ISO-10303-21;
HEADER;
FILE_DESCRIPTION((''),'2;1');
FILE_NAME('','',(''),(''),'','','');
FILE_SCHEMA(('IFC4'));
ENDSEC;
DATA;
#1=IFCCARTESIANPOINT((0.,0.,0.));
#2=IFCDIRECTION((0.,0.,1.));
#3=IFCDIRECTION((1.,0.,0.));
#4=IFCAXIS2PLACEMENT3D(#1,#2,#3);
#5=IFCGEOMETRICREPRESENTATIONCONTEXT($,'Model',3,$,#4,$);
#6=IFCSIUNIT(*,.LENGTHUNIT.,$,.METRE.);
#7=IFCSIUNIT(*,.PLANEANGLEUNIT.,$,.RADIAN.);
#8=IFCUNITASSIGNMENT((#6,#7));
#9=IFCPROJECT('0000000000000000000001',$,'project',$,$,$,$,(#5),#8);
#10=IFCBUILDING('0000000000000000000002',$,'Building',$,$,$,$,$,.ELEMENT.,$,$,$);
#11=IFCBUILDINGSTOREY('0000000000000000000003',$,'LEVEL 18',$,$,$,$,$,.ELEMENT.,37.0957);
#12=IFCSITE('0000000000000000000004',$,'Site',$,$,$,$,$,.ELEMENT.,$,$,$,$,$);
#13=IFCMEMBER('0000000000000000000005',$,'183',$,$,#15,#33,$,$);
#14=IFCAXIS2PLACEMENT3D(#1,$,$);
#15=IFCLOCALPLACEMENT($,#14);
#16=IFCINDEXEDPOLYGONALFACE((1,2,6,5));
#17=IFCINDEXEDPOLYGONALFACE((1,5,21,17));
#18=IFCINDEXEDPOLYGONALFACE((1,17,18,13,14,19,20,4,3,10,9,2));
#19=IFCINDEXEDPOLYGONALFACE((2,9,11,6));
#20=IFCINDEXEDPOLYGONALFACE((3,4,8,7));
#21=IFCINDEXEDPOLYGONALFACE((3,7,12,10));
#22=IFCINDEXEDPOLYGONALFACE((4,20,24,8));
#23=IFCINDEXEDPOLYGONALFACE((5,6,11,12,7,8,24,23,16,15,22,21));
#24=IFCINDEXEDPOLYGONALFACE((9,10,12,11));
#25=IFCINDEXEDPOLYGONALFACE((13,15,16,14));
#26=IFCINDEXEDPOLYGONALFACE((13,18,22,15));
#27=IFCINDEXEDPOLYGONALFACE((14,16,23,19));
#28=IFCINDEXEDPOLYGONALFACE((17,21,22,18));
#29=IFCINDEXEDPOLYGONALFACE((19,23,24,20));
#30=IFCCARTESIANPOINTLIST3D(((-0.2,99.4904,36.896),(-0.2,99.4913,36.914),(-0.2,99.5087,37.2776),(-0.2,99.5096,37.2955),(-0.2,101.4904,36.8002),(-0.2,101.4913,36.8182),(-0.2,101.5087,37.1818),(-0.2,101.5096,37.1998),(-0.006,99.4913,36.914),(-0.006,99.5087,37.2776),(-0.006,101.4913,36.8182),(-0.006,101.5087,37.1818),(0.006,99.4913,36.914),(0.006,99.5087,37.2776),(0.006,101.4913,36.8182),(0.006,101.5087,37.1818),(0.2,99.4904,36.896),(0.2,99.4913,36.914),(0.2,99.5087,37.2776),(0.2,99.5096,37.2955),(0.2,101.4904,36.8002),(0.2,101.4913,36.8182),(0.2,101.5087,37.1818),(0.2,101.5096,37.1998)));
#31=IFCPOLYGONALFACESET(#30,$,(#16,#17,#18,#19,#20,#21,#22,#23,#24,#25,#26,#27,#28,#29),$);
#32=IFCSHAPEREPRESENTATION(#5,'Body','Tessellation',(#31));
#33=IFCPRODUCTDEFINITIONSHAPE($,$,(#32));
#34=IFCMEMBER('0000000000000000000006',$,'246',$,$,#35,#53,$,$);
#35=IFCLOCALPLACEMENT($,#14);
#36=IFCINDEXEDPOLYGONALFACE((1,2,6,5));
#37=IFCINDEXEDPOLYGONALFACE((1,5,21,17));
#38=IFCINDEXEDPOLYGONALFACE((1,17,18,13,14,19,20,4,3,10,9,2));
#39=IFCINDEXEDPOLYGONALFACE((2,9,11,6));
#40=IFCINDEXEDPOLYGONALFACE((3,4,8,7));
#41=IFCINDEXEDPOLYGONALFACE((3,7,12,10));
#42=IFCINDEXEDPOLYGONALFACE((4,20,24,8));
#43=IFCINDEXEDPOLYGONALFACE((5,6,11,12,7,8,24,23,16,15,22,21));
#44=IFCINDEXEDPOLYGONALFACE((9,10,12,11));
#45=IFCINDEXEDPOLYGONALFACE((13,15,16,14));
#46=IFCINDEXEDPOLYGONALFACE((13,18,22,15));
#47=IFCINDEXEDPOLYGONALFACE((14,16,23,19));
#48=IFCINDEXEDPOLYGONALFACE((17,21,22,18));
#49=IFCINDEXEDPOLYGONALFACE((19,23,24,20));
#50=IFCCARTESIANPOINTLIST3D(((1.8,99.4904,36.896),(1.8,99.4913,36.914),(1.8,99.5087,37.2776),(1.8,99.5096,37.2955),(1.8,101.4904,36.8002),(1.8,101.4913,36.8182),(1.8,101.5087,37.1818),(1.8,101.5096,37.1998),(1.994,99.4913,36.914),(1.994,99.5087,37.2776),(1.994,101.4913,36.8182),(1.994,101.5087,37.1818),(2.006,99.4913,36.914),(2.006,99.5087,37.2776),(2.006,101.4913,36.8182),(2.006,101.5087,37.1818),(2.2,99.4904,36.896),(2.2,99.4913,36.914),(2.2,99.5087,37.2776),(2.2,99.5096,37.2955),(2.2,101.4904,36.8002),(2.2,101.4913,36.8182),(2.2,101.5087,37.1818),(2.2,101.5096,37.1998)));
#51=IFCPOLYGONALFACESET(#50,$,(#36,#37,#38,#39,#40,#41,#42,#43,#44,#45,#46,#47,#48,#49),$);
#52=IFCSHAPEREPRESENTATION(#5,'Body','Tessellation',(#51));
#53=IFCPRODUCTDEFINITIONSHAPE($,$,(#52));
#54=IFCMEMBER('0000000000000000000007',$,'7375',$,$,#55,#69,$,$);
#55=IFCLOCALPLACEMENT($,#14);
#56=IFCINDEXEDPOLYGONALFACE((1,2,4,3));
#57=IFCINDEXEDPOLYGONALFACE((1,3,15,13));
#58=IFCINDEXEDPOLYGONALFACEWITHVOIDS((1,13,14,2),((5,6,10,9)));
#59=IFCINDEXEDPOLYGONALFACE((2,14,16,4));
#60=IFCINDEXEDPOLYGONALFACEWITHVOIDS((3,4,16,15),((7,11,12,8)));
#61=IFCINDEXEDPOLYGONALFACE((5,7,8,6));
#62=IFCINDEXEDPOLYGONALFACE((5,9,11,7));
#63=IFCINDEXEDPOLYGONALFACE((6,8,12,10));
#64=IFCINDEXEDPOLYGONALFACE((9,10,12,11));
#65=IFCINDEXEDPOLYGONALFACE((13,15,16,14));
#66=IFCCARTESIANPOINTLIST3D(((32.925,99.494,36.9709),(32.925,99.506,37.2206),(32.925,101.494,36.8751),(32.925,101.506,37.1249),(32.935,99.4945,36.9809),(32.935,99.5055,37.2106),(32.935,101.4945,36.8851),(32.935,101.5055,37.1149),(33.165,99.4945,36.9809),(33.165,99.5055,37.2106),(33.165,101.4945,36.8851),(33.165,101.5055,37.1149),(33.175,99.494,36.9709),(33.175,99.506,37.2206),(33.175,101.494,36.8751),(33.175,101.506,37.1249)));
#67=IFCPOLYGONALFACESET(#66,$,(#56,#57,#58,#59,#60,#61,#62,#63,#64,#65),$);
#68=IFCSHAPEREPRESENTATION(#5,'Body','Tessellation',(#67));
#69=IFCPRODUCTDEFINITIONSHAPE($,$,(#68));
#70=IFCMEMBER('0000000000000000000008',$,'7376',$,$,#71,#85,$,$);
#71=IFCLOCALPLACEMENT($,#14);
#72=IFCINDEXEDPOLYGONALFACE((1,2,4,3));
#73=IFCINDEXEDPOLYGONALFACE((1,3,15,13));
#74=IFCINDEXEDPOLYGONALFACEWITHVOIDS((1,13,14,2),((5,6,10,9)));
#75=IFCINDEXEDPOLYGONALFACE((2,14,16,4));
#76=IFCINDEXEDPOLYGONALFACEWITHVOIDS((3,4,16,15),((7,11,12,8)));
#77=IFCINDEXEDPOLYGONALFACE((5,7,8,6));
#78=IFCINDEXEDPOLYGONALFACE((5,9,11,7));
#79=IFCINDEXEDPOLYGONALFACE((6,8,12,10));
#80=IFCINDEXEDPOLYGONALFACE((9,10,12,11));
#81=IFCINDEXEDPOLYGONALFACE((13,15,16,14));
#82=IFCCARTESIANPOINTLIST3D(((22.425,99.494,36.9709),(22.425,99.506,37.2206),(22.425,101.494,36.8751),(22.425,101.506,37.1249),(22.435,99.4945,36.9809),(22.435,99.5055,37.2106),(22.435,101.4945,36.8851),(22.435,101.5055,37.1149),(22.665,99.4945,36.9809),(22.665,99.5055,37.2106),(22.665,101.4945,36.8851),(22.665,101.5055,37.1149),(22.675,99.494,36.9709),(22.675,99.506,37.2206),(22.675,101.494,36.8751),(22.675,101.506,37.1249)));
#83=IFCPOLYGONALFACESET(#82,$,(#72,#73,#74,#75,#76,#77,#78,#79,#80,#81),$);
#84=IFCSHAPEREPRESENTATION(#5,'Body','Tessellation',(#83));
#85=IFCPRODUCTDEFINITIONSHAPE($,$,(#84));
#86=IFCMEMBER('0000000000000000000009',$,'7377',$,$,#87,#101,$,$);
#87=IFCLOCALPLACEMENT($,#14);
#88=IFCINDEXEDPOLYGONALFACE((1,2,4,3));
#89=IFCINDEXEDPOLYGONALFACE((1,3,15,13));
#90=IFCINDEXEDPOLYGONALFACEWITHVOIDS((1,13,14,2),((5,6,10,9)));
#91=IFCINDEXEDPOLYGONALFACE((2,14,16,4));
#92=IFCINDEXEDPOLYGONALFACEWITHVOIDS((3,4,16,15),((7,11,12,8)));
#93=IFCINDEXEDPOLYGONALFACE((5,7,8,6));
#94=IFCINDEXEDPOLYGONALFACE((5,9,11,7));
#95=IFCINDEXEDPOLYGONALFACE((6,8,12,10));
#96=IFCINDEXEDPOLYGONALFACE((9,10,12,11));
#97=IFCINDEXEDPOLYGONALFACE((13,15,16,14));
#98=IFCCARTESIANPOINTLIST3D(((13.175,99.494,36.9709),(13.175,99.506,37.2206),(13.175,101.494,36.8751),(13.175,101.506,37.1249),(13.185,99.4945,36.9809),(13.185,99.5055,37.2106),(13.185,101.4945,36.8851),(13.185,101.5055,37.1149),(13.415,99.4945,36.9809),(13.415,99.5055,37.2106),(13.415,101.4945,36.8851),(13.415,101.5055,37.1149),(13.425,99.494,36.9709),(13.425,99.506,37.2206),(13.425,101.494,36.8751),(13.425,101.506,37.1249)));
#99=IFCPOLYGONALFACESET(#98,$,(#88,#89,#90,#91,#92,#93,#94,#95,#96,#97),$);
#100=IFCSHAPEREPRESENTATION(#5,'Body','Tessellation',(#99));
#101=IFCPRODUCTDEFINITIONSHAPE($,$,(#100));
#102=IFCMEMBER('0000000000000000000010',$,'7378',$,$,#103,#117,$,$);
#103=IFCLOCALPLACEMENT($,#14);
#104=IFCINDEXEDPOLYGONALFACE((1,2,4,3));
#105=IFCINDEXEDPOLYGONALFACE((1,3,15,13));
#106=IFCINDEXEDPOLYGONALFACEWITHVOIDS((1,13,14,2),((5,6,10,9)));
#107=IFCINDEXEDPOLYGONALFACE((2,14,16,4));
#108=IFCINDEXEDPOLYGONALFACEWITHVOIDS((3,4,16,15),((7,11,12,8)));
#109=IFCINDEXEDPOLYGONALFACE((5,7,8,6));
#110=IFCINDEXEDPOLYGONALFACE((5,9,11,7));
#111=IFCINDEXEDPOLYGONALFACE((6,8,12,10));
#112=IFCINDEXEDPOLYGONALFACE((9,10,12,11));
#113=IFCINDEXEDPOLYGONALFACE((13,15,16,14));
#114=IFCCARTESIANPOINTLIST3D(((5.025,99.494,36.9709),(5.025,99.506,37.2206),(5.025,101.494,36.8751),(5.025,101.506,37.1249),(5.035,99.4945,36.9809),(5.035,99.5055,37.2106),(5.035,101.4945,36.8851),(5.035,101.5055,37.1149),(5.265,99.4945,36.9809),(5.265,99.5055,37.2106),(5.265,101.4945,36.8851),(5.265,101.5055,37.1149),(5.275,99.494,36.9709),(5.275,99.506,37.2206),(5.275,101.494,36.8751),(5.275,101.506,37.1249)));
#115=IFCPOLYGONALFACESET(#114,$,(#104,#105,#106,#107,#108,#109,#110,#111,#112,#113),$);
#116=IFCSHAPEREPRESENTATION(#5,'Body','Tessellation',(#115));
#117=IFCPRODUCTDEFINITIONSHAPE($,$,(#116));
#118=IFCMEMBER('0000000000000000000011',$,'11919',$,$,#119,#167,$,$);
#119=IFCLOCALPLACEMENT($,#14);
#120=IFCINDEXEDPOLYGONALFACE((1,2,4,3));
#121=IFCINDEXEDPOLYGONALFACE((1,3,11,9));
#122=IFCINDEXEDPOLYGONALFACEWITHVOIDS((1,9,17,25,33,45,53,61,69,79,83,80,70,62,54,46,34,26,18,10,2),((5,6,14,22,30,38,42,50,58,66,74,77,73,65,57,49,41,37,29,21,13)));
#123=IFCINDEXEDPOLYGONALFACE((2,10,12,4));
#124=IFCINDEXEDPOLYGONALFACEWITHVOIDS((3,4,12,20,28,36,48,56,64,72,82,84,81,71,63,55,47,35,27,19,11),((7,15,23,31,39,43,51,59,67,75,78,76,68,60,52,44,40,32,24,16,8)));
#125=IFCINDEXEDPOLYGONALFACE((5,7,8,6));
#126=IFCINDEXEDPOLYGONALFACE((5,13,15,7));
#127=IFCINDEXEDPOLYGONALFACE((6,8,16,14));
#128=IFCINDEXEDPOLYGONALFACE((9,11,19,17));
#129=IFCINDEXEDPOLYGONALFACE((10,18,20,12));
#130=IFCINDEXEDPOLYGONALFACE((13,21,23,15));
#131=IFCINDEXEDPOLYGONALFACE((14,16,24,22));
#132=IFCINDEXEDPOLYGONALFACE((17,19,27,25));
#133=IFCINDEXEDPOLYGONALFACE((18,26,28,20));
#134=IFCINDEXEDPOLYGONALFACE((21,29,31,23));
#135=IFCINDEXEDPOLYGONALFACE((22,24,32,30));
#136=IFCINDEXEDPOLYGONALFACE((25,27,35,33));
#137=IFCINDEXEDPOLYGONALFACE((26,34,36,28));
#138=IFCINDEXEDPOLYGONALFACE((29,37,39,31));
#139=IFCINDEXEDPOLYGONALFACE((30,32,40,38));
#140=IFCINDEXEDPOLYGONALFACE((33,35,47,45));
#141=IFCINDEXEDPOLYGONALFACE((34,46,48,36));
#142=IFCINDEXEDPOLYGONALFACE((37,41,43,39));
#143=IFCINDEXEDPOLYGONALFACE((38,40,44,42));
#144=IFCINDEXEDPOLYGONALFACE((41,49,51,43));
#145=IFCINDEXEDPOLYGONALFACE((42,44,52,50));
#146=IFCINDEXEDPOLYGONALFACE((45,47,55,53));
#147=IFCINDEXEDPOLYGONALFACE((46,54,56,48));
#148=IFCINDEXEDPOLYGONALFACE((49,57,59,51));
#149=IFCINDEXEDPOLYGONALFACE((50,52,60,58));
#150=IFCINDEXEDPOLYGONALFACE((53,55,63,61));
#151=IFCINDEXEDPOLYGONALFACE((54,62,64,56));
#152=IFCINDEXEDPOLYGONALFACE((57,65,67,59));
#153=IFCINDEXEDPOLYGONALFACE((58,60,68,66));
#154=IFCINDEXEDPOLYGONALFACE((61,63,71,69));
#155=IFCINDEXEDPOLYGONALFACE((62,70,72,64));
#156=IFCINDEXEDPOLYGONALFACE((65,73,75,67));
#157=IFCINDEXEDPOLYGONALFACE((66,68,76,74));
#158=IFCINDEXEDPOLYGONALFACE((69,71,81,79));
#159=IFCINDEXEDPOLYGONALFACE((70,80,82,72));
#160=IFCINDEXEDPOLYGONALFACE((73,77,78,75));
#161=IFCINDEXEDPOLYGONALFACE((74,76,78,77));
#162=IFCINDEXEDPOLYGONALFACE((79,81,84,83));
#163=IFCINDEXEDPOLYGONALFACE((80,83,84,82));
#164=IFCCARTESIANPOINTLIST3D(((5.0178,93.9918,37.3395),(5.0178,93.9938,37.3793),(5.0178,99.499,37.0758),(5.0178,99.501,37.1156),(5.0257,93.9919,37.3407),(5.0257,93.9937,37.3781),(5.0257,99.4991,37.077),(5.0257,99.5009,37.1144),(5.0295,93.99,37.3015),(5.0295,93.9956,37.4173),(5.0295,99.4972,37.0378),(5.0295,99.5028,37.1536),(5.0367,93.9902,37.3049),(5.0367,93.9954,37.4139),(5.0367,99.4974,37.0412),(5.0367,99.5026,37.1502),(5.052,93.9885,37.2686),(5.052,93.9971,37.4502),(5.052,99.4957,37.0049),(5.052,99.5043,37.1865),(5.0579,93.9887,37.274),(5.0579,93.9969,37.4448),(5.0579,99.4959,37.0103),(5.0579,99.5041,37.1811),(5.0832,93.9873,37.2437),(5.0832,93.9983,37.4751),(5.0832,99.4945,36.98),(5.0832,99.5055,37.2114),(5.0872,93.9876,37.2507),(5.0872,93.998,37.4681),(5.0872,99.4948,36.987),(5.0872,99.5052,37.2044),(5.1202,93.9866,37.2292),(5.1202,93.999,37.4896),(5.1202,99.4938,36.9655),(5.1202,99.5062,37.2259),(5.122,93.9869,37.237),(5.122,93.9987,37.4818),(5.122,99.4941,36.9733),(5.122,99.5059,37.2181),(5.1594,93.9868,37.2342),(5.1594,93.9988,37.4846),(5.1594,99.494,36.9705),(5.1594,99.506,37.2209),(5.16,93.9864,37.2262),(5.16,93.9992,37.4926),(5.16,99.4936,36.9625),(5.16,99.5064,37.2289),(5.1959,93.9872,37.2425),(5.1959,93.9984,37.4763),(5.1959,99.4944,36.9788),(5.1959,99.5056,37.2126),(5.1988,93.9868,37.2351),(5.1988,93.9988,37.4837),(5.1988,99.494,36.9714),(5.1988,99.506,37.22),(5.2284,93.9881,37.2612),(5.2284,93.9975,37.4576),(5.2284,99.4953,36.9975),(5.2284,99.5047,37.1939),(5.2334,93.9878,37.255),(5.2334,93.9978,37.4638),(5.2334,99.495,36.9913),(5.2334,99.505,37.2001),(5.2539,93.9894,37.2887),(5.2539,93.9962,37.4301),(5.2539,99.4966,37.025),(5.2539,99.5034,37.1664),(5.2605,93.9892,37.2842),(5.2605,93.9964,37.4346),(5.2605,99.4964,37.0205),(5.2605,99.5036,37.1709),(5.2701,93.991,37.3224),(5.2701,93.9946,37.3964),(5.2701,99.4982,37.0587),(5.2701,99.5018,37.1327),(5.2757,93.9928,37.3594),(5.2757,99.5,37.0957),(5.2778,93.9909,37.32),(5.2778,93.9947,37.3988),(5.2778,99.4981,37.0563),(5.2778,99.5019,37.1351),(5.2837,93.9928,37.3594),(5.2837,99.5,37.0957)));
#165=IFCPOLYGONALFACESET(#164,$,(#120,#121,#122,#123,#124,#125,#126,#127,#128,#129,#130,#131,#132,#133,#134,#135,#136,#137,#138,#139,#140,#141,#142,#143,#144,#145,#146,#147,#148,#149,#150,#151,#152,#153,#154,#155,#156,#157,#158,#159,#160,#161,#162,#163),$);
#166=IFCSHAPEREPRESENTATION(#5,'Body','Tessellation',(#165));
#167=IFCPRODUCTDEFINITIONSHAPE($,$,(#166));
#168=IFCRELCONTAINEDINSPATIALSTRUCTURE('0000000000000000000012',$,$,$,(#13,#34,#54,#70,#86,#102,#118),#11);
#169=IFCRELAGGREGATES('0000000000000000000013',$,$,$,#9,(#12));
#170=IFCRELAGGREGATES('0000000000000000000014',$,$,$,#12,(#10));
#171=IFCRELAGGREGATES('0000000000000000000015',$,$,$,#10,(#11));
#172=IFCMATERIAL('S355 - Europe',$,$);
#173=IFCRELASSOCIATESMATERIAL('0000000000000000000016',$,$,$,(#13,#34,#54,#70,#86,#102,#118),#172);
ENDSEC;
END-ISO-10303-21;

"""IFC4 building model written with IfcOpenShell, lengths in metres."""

from ifc_helpers import new_model, si_unit, frame, origin_with_axes, origin_2d_with_axis, place, context, project, spatial, hollow_rectangle, hollow_circle, i_section, extrude, material, material_profile, profile_set, profile_usage, element, save


model = new_model("IFC4")

# Units and contexts
model_context = context("Model", 3, world=origin_with_axes())
ifc_project = project(units=[si_unit("LENGTHUNIT", "METRE"), si_unit("PLANEANGLEUNIT", "RADIAN")], contexts=[model_context])

# Site, building, storey
site = spatial("IfcSite", under=ifc_project, Name="Site", CompositionType="ELEMENT")
building = spatial("IfcBuilding", under=site, Name="Building", CompositionType="ELEMENT")
storey = spatial("IfcBuildingStorey", under=building, Name="LEVEL 18", CompositionType="ELEMENT", Elevation=37.0957)

# Shared definitions
ifc_material = material(Name="S355 - Europe")

# Members
ifc_material_profile_1 = material_profile(ifc_material, i_section(OverallWidth=0.4, OverallDepth=0.4, WebThickness=0.012, FlangeThickness=0.018, at=origin_2d_with_axis()))
ifc_profile_set_1 = profile_set([ifc_material_profile_1])
ifc_profile_usage_1 = profile_usage(ifc_profile_set_1, cardinal=10)
member_1_placement = place(None, frame((0.0, 101.5, 37.0), z_axis=(0.0, -0.998856, 0.047828), x_axis=(1.0, 0.0, 0.0)))
element("IfcMember", 1, at=member_1_placement, inside=storey, material=ifc_profile_usage_1, Name="183", context=model_context, shape_type="SweptSolid", body=[
    extrude(i_section(OverallWidth=0.4, OverallDepth=0.4, WebThickness=0.012, FlangeThickness=0.018, at=origin_2d_with_axis()), origin_with_axes(), (0.0, 0.0, 1.0), 2.0023),
])
ifc_material_profile_2 = material_profile(ifc_material, i_section(OverallWidth=0.4, OverallDepth=0.4, WebThickness=0.012, FlangeThickness=0.018, at=origin_2d_with_axis()))
ifc_profile_set_2 = profile_set([ifc_material_profile_2])
ifc_profile_usage_2 = profile_usage(ifc_profile_set_2, cardinal=10)
member_2_placement = place(None, frame((2.0, 101.5, 37.0), z_axis=(0.0, -0.998856, 0.047828), x_axis=(1.0, 0.0, 0.0)))
element("IfcMember", 2, at=member_2_placement, inside=storey, material=ifc_profile_usage_2, Name="246", context=model_context, shape_type="SweptSolid", body=[
    extrude(i_section(OverallWidth=0.4, OverallDepth=0.4, WebThickness=0.012, FlangeThickness=0.018, at=origin_2d_with_axis()), origin_with_axes(), (0.0, 0.0, 1.0), 2.0023),
])
ifc_material_profile_3 = material_profile(ifc_material, hollow_rectangle(XDim=0.25, YDim=0.25, WallThickness=0.01, at=origin_2d_with_axis()))
ifc_profile_set_3 = profile_set([ifc_material_profile_3])
ifc_profile_usage_3 = profile_usage(ifc_profile_set_3, cardinal=10)
member_3_placement = place(None, frame((33.05, 101.5, 37.0), z_axis=(0.0, -0.998856, 0.047828), x_axis=(1.0, 0.0, 0.0)))
element("IfcMember", 3, at=member_3_placement, inside=storey, material=ifc_profile_usage_3, Name="7375", context=model_context, shape_type="SweptSolid", body=[
    extrude(hollow_rectangle(XDim=0.25, YDim=0.25, WallThickness=0.01, at=origin_2d_with_axis()), origin_with_axes(), (0.0, 0.0, 1.0), 2.0023),
])
ifc_material_profile_4 = material_profile(ifc_material, hollow_rectangle(XDim=0.25, YDim=0.25, WallThickness=0.01, at=origin_2d_with_axis()))
ifc_profile_set_4 = profile_set([ifc_material_profile_4])
ifc_profile_usage_4 = profile_usage(ifc_profile_set_4, cardinal=10)
member_4_placement = place(None, frame((22.55, 101.5, 37.0), z_axis=(0.0, -0.998856, 0.047828), x_axis=(1.0, 0.0, 0.0)))
element("IfcMember", 4, at=member_4_placement, inside=storey, material=ifc_profile_usage_4, Name="7376", context=model_context, shape_type="SweptSolid", body=[
    extrude(hollow_rectangle(XDim=0.25, YDim=0.25, WallThickness=0.01, at=origin_2d_with_axis()), origin_with_axes(), (0.0, 0.0, 1.0), 2.0023),
])
ifc_material_profile_5 = material_profile(ifc_material, hollow_rectangle(XDim=0.25, YDim=0.25, WallThickness=0.01, at=origin_2d_with_axis()))
ifc_profile_set_5 = profile_set([ifc_material_profile_5])
ifc_profile_usage_5 = profile_usage(ifc_profile_set_5, cardinal=10)
member_5_placement = place(None, frame((13.3, 101.5, 37.0), z_axis=(0.0, -0.998856, 0.047828), x_axis=(1.0, 0.0, 0.0)))
element("IfcMember", 5, at=member_5_placement, inside=storey, material=ifc_profile_usage_5, Name="7377", context=model_context, shape_type="SweptSolid", body=[
    extrude(hollow_rectangle(XDim=0.25, YDim=0.25, WallThickness=0.01, at=origin_2d_with_axis()), origin_with_axes(), (0.0, 0.0, 1.0), 2.0023),
])
ifc_material_profile_6 = material_profile(ifc_material, hollow_rectangle(XDim=0.25, YDim=0.25, WallThickness=0.01, at=origin_2d_with_axis()))
ifc_profile_set_6 = profile_set([ifc_material_profile_6])
ifc_profile_usage_6 = profile_usage(ifc_profile_set_6, cardinal=10)
member_6_placement = place(None, frame((5.15, 101.5, 37.0), z_axis=(0.0, -0.998856, 0.047828), x_axis=(1.0, 0.0, 0.0)))
element("IfcMember", 6, at=member_6_placement, inside=storey, material=ifc_profile_usage_6, Name="7378", context=model_context, shape_type="SweptSolid", body=[
    extrude(hollow_rectangle(XDim=0.25, YDim=0.25, WallThickness=0.01, at=origin_2d_with_axis()), origin_with_axes(), (0.0, 0.0, 1.0), 2.0023),
])
ifc_material_profile_7 = material_profile(ifc_material, hollow_circle(Radius=0.1337, WallThickness=0.008, at=origin_2d_with_axis()))
ifc_profile_set_7 = profile_set([ifc_material_profile_7])
ifc_profile_usage_7 = profile_usage(ifc_profile_set_7, cardinal=10)
member_7_placement = place(None, frame((5.15, 99.5, 37.0957), z_axis=(0.0, -0.998856, 0.047828), x_axis=(1.0, 0.0, 0.0)))
element("IfcMember", 7, at=member_7_placement, inside=storey, material=ifc_profile_usage_7, Name="11919", context=model_context, shape_type="SweptSolid", body=[
    extrude(hollow_circle(Radius=0.1337, WallThickness=0.008, at=origin_2d_with_axis()), origin_with_axes(), (0.0, 0.0, 1.0), 5.5135),
])

save(model, "model.ifc")
